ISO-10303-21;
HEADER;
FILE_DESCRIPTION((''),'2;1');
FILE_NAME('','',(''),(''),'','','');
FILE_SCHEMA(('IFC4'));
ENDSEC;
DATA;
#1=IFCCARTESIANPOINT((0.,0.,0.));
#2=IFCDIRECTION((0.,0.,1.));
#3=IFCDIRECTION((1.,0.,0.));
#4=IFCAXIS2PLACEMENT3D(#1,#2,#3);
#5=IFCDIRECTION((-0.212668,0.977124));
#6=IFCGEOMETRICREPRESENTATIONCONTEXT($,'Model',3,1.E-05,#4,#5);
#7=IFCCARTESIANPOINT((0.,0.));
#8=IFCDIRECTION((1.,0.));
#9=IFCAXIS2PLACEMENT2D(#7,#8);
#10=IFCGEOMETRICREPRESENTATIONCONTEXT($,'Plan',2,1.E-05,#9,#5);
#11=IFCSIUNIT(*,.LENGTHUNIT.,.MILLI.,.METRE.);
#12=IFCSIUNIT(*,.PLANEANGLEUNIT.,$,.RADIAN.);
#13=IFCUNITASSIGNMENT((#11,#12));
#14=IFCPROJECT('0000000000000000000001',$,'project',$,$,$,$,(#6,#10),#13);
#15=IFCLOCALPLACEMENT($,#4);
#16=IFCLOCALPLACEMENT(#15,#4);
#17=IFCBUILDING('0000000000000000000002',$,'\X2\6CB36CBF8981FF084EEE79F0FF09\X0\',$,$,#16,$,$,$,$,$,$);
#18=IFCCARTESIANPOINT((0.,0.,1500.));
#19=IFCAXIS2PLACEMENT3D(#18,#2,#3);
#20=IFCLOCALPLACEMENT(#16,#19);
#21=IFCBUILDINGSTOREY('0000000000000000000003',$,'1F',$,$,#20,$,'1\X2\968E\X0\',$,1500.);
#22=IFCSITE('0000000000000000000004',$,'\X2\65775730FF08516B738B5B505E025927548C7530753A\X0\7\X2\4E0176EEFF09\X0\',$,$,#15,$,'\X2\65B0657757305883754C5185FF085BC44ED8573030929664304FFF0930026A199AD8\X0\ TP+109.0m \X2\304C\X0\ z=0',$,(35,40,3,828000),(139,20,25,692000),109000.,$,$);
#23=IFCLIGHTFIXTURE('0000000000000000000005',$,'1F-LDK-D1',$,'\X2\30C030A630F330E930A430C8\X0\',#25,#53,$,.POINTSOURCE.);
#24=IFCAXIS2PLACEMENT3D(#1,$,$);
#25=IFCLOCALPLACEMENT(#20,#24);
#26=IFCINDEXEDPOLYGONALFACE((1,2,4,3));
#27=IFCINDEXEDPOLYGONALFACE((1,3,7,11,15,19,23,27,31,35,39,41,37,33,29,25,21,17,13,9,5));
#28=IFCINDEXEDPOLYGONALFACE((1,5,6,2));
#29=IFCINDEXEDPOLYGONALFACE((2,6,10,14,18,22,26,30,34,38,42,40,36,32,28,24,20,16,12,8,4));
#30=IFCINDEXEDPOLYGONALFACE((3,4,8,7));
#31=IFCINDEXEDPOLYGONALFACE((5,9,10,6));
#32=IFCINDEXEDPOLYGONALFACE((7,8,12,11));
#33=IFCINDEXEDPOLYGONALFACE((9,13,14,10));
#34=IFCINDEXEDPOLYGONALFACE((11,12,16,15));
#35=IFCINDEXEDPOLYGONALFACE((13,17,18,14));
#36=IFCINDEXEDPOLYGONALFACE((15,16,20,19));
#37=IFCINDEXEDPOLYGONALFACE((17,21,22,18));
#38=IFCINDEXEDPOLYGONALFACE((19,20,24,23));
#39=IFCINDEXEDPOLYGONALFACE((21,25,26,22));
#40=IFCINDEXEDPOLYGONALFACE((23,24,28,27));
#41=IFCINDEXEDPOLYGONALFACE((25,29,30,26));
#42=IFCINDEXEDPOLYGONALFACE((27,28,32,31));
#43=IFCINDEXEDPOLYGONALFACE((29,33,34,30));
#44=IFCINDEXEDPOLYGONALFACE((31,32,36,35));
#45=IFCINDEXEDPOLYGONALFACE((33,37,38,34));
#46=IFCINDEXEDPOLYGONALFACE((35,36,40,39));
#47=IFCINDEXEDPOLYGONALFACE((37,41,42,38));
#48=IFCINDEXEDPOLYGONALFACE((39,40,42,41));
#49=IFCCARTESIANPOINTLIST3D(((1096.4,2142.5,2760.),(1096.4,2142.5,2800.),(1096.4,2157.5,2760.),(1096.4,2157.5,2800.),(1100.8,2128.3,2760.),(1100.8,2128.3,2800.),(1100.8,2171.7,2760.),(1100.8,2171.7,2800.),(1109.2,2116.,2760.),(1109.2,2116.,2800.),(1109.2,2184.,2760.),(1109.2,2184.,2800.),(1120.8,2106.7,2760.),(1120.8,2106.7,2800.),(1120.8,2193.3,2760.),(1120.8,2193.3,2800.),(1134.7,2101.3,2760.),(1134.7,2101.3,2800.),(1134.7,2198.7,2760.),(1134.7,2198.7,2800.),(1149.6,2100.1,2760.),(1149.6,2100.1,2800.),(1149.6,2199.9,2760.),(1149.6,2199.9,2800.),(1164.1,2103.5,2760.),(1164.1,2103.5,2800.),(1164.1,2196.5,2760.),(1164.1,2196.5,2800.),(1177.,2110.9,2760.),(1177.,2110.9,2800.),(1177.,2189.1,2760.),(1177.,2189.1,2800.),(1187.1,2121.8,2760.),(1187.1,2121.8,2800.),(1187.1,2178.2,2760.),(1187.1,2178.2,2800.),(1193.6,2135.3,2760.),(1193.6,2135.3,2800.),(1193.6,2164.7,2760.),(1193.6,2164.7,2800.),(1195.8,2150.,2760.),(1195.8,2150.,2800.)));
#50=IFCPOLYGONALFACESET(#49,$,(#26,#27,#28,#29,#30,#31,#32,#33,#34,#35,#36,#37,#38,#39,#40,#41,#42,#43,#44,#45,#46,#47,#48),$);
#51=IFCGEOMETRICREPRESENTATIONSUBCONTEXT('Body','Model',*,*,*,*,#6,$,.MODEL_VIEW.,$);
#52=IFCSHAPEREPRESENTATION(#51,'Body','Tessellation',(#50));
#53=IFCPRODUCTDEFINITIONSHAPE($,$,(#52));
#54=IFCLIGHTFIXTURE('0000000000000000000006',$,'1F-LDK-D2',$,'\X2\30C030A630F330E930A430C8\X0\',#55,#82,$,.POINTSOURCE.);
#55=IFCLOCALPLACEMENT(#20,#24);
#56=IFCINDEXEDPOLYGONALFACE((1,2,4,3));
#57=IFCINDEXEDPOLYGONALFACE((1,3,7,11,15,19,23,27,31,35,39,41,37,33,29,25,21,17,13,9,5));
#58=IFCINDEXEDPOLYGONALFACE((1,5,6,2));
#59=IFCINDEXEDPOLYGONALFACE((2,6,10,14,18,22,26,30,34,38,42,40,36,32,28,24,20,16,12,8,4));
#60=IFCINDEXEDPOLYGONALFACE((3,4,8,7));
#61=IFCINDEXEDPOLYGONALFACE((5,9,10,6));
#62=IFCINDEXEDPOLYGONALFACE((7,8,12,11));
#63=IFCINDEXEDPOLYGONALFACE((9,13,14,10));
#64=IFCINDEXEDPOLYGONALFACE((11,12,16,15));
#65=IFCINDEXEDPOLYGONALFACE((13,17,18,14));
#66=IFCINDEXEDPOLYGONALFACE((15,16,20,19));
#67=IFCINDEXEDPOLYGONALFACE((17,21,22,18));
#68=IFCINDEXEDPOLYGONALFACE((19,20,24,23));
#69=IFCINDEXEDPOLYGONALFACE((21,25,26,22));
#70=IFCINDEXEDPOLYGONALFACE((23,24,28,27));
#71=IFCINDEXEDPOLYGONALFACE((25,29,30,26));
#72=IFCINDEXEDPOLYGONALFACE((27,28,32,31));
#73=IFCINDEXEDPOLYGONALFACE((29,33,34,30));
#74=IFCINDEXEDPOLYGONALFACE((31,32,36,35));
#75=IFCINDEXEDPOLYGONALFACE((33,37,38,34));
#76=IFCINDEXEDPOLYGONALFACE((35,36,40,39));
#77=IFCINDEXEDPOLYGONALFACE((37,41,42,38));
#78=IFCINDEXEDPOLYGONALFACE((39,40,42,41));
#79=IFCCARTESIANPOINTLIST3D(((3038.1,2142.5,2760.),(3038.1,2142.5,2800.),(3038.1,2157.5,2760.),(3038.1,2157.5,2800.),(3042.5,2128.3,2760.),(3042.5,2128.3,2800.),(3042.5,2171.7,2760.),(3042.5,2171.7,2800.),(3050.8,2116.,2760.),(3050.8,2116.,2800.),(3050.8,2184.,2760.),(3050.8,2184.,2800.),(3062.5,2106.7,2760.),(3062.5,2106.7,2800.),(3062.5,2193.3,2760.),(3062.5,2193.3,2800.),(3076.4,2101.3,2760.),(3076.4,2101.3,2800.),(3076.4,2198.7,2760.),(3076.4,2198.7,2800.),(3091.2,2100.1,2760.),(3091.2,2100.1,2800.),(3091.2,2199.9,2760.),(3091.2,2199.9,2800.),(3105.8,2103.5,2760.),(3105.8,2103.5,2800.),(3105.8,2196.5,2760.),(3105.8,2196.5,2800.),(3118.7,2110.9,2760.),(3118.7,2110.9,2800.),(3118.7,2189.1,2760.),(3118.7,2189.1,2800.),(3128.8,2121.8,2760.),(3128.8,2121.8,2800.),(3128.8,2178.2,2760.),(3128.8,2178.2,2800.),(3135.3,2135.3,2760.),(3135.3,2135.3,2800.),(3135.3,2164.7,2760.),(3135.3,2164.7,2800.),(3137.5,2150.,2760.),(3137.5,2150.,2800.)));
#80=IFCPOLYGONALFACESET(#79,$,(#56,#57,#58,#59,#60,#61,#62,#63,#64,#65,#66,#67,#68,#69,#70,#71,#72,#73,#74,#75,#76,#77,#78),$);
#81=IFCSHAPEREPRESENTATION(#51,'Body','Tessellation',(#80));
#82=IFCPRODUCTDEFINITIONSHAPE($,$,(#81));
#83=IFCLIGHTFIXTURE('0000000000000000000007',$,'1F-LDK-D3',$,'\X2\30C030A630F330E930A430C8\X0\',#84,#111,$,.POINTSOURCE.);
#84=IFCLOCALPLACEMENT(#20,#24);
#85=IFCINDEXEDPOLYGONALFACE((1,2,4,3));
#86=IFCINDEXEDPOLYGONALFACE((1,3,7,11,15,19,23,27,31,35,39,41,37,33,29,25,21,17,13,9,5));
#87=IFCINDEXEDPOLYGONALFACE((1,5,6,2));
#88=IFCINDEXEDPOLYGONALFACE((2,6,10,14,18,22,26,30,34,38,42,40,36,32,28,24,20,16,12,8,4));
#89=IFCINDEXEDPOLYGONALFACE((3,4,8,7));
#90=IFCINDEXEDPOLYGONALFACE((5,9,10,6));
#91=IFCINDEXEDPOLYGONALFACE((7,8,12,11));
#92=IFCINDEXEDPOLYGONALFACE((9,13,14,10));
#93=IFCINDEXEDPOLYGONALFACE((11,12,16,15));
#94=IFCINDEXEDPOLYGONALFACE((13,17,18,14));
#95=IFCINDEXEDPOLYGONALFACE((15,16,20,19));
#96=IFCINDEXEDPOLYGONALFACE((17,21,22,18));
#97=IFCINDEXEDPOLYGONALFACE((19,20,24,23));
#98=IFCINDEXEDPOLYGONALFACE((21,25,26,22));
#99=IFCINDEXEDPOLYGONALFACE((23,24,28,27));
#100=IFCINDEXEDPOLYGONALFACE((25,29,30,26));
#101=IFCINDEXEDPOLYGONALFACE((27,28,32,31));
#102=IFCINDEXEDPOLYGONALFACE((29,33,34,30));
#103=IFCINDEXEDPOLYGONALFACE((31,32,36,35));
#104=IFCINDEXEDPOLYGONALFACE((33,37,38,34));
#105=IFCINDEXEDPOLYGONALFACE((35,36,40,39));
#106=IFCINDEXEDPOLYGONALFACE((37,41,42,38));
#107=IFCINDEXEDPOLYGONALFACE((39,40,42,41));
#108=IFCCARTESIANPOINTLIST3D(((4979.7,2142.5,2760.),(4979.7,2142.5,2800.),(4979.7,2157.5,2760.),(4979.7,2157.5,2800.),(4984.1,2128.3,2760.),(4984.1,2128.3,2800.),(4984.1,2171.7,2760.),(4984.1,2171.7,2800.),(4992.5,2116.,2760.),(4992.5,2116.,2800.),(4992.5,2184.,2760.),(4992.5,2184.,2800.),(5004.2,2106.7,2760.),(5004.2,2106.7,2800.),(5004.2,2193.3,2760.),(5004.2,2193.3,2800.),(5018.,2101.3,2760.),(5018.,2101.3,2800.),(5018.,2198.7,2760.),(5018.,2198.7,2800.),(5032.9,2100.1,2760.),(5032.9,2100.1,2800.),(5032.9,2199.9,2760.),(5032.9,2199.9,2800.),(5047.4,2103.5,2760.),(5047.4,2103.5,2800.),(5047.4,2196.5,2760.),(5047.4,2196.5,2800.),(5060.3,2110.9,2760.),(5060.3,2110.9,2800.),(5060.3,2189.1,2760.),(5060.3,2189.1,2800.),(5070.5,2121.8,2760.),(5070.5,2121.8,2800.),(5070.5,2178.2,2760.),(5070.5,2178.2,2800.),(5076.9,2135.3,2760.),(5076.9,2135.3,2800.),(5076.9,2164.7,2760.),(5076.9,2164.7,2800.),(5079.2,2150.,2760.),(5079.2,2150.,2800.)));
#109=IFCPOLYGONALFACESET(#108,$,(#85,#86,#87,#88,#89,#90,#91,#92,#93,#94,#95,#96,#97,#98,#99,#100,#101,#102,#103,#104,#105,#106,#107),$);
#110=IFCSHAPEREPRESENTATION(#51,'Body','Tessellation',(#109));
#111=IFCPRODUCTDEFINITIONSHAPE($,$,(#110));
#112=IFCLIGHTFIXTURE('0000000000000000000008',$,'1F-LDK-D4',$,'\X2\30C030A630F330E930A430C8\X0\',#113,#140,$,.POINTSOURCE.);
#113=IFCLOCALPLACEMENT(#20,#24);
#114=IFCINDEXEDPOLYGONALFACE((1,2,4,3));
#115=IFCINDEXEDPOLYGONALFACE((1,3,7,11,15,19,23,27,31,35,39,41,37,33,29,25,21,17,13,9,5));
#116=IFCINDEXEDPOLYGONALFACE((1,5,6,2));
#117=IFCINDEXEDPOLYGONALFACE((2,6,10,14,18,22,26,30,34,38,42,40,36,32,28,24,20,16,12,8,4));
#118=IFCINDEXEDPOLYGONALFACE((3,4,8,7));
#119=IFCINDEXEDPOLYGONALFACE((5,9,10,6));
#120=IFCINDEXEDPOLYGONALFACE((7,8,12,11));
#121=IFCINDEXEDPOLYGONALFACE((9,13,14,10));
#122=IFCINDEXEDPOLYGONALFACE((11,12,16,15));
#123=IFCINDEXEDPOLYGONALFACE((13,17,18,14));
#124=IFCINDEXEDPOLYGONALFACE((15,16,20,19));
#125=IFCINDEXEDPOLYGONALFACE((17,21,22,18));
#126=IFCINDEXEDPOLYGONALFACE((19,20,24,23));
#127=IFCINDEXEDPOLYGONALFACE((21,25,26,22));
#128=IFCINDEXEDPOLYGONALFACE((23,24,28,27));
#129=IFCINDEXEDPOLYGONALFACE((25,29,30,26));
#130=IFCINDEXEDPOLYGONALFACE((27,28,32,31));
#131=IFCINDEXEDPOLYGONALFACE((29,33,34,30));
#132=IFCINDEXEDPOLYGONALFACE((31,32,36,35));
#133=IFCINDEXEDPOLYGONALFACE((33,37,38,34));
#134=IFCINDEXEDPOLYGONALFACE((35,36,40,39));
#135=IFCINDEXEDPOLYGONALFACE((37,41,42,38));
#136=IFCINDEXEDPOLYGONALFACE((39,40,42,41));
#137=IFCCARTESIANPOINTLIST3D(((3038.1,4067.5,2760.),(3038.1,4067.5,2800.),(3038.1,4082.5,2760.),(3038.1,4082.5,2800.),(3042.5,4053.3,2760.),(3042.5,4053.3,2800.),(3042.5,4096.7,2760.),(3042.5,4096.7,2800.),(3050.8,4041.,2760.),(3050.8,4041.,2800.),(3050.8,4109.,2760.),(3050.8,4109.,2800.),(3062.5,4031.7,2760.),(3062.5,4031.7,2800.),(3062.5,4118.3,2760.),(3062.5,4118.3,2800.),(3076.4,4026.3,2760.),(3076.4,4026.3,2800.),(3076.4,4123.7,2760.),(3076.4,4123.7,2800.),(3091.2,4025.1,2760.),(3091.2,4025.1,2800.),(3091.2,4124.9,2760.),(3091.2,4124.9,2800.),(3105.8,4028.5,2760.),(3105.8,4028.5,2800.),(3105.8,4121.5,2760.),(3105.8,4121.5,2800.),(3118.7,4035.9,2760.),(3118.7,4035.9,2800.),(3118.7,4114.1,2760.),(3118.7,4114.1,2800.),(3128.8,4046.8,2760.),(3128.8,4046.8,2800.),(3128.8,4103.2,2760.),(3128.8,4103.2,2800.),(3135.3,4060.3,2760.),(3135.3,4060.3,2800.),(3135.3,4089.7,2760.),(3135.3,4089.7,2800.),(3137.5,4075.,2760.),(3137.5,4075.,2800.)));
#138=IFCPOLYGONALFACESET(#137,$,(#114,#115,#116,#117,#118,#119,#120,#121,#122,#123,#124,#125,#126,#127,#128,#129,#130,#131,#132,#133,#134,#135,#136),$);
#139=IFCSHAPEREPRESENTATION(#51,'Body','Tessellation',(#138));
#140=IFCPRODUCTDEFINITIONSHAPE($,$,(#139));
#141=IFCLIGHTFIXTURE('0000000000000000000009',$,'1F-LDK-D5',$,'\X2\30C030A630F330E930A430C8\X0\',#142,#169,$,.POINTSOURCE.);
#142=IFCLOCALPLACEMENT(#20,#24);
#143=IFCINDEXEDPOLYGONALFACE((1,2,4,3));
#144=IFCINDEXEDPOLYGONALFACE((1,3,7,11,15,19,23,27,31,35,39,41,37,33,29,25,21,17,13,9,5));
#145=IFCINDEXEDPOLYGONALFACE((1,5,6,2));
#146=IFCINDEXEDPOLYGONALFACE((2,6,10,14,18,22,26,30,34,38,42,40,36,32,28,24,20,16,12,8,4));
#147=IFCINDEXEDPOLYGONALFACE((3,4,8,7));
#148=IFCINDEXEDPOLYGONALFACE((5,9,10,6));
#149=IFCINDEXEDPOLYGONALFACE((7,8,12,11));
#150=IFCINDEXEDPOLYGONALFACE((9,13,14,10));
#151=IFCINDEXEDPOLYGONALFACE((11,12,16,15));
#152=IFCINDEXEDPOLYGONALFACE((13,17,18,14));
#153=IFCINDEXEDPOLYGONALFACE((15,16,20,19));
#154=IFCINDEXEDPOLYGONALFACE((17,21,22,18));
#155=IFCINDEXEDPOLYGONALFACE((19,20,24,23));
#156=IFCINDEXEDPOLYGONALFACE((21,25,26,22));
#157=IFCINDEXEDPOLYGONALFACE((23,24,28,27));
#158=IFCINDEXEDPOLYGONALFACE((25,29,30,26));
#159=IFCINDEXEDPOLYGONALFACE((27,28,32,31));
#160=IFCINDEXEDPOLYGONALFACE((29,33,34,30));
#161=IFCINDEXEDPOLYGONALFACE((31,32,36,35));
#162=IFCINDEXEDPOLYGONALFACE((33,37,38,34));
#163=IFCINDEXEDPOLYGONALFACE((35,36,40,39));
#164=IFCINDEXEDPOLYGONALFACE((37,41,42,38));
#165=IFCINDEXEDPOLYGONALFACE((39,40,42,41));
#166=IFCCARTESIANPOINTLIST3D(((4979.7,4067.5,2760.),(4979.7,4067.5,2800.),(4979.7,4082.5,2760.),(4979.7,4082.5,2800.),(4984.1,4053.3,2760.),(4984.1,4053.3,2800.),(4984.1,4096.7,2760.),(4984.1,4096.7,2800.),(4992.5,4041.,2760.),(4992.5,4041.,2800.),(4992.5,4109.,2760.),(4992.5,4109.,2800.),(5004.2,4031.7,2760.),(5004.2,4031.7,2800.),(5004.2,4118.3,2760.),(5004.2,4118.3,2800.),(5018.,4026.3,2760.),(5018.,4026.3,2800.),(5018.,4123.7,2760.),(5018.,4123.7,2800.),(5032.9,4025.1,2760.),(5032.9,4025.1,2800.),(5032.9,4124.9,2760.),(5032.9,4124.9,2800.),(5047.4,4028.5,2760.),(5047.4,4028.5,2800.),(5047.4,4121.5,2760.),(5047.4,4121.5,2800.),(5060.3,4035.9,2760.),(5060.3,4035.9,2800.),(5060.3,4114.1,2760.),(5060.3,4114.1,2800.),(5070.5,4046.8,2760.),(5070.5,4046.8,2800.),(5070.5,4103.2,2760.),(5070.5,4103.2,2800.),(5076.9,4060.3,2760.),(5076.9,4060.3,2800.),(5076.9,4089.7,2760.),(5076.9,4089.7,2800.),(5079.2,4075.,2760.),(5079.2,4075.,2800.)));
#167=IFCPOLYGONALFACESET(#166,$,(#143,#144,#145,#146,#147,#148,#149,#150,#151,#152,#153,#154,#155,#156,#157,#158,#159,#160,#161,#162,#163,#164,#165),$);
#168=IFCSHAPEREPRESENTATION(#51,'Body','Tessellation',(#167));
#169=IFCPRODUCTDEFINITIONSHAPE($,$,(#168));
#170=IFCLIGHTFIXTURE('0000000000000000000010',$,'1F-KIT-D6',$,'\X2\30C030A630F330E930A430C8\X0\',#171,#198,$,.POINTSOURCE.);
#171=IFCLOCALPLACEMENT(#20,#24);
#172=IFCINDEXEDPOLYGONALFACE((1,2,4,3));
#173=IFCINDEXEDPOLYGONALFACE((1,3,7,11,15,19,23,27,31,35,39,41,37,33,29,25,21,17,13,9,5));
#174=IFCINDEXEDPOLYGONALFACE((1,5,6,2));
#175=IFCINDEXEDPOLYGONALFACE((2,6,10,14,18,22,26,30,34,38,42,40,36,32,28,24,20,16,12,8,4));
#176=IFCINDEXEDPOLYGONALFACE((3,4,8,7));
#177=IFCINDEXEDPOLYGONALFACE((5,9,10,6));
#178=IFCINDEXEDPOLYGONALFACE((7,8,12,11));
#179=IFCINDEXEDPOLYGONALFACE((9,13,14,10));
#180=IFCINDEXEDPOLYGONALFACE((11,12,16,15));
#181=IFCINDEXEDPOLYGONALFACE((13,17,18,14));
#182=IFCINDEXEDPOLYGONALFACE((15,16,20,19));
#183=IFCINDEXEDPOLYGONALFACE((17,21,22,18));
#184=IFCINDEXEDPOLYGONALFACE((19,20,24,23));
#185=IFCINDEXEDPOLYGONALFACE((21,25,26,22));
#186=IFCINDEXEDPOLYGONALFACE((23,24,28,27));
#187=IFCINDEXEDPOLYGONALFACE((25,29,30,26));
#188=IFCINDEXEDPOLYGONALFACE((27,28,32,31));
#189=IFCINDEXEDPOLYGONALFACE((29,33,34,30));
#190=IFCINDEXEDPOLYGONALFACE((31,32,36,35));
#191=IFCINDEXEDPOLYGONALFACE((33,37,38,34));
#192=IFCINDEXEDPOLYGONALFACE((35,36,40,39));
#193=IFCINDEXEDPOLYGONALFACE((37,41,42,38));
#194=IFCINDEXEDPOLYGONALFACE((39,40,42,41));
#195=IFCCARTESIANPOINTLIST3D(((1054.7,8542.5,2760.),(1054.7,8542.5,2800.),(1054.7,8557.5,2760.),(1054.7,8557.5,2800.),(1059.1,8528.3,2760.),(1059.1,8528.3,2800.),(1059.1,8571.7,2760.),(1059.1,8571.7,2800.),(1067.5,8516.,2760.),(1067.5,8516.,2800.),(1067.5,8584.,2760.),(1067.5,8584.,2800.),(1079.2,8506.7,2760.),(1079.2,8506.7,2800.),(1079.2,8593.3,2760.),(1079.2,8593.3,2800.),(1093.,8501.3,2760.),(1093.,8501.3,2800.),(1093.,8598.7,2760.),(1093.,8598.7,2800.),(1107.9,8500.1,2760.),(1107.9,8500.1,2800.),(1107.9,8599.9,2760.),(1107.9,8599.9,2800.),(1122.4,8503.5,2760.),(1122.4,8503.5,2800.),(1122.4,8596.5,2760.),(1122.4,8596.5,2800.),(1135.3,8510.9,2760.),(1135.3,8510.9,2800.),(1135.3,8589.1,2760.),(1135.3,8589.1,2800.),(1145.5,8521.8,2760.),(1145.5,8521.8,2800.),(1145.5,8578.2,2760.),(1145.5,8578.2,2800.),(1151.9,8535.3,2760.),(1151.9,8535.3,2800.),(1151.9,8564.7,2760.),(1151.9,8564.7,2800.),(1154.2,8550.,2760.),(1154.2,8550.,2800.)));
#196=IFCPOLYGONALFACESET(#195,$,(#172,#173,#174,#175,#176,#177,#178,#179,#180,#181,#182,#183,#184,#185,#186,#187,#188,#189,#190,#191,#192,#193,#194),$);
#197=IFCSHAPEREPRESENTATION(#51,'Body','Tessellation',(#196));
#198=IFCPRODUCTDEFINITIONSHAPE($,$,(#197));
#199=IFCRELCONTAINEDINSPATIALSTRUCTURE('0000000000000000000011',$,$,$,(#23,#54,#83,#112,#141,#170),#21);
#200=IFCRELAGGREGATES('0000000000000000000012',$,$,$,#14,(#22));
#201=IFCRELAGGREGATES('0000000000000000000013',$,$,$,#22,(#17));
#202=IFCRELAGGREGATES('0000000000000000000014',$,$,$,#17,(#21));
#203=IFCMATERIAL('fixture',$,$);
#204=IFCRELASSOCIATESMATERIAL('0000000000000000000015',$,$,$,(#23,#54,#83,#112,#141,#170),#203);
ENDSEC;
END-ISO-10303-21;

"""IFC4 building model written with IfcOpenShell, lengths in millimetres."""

from ifc_helpers import new_model, si_unit, direction, frame, frame_2d, origin_with_axes, origin_2d_with_axis, place, context, subcontext, project, spatial, circle, extrude, material, element, save


model = new_model("IFC4")

# Units and contexts
model_context = context("Model", 3, precision=1e-05, world=origin_with_axes(), true_north=direction((-0.212668, 0.977124)))
plan_context = context("Plan", 2, precision=1e-05, world=origin_2d_with_axis(), true_north=direction((-0.212668, 0.977124)))
body_context = subcontext(model_context, "Body", "Model", "MODEL_VIEW")
ifc_project = project(units=[si_unit("LENGTHUNIT", "METRE", prefix="MILLI"), si_unit("PLANEANGLEUNIT", "RADIAN")], contexts=[model_context, plan_context])

# Site, building, storey
site_placement = place(None, origin_with_axes())
site = spatial("IfcSite", under=ifc_project, at=site_placement, Name="敷地（八王子市大和田町7丁目）", LongName="新敷地境界内（寄付地を除く）。標高 TP+109.0m が z=0", RefLatitude=(35, 40, 3, 828000), RefLongitude=(139, 20, 25, 692000), RefElevation=109000.0)
building_placement = place(site_placement, origin_with_axes())
building = spatial("IfcBuilding", under=site, at=building_placement, Name="河沿要（仮称）")
storey_placement = place(building_placement, frame((0.0, 0.0, 1500.0), z_axis=(0.0, 0.0, 1.0), x_axis=(1.0, 0.0, 0.0)))
storey = spatial("IfcBuildingStorey", under=building, at=storey_placement, Name="1F", LongName="1階", Elevation=1500.0)

# Light fixtures
ifc_material = material(Name="fixture")
light_fixture_1_placement = place(storey_placement, origin_with_axes())
element("IfcLightFixture", 1, at=light_fixture_1_placement, inside=storey, material=ifc_material, Name="1F-LDK-D1", ObjectType="ダウンライト", PredefinedType="POINTSOURCE", context=body_context, shape_type="SweptSolid", body=[
    extrude(circle(Radius=50.0, at=frame_2d((1145.8, 2150.0))), frame((0.0, 0.0, 2760.0)), (0.0, 0.0, 1.0), 40.0),
])
light_fixture_2_placement = place(storey_placement, origin_with_axes())
element("IfcLightFixture", 2, at=light_fixture_2_placement, inside=storey, material=ifc_material, Name="1F-LDK-D2", ObjectType="ダウンライト", PredefinedType="POINTSOURCE", context=body_context, shape_type="SweptSolid", body=[
    extrude(circle(Radius=50.0, at=frame_2d((3087.5, 2150.0))), frame((0.0, 0.0, 2760.0)), (0.0, 0.0, 1.0), 40.0),
])
light_fixture_3_placement = place(storey_placement, origin_with_axes())
element("IfcLightFixture", 3, at=light_fixture_3_placement, inside=storey, material=ifc_material, Name="1F-LDK-D3", ObjectType="ダウンライト", PredefinedType="POINTSOURCE", context=body_context, shape_type="SweptSolid", body=[
    extrude(circle(Radius=50.0, at=frame_2d((5029.2, 2150.0))), frame((0.0, 0.0, 2760.0)), (0.0, 0.0, 1.0), 40.0),
])
light_fixture_4_placement = place(storey_placement, origin_with_axes())
element("IfcLightFixture", 4, at=light_fixture_4_placement, inside=storey, material=ifc_material, Name="1F-LDK-D4", ObjectType="ダウンライト", PredefinedType="POINTSOURCE", context=body_context, shape_type="SweptSolid", body=[
    extrude(circle(Radius=50.0, at=frame_2d((3087.5, 4075.0))), frame((0.0, 0.0, 2760.0)), (0.0, 0.0, 1.0), 40.0),
])
light_fixture_5_placement = place(storey_placement, origin_with_axes())
element("IfcLightFixture", 5, at=light_fixture_5_placement, inside=storey, material=ifc_material, Name="1F-LDK-D5", ObjectType="ダウンライト", PredefinedType="POINTSOURCE", context=body_context, shape_type="SweptSolid", body=[
    extrude(circle(Radius=50.0, at=frame_2d((5029.2, 4075.0))), frame((0.0, 0.0, 2760.0)), (0.0, 0.0, 1.0), 40.0),
])
light_fixture_6_placement = place(storey_placement, origin_with_axes())
element("IfcLightFixture", 6, at=light_fixture_6_placement, inside=storey, material=ifc_material, Name="1F-KIT-D6", ObjectType="ダウンライト", PredefinedType="POINTSOURCE", context=body_context, shape_type="SweptSolid", body=[
    extrude(circle(Radius=50.0, at=frame_2d((1104.2, 8550.0))), frame((0.0, 0.0, 2760.0)), (0.0, 0.0, 1.0), 40.0),
])

save(model, "model.ifc")
